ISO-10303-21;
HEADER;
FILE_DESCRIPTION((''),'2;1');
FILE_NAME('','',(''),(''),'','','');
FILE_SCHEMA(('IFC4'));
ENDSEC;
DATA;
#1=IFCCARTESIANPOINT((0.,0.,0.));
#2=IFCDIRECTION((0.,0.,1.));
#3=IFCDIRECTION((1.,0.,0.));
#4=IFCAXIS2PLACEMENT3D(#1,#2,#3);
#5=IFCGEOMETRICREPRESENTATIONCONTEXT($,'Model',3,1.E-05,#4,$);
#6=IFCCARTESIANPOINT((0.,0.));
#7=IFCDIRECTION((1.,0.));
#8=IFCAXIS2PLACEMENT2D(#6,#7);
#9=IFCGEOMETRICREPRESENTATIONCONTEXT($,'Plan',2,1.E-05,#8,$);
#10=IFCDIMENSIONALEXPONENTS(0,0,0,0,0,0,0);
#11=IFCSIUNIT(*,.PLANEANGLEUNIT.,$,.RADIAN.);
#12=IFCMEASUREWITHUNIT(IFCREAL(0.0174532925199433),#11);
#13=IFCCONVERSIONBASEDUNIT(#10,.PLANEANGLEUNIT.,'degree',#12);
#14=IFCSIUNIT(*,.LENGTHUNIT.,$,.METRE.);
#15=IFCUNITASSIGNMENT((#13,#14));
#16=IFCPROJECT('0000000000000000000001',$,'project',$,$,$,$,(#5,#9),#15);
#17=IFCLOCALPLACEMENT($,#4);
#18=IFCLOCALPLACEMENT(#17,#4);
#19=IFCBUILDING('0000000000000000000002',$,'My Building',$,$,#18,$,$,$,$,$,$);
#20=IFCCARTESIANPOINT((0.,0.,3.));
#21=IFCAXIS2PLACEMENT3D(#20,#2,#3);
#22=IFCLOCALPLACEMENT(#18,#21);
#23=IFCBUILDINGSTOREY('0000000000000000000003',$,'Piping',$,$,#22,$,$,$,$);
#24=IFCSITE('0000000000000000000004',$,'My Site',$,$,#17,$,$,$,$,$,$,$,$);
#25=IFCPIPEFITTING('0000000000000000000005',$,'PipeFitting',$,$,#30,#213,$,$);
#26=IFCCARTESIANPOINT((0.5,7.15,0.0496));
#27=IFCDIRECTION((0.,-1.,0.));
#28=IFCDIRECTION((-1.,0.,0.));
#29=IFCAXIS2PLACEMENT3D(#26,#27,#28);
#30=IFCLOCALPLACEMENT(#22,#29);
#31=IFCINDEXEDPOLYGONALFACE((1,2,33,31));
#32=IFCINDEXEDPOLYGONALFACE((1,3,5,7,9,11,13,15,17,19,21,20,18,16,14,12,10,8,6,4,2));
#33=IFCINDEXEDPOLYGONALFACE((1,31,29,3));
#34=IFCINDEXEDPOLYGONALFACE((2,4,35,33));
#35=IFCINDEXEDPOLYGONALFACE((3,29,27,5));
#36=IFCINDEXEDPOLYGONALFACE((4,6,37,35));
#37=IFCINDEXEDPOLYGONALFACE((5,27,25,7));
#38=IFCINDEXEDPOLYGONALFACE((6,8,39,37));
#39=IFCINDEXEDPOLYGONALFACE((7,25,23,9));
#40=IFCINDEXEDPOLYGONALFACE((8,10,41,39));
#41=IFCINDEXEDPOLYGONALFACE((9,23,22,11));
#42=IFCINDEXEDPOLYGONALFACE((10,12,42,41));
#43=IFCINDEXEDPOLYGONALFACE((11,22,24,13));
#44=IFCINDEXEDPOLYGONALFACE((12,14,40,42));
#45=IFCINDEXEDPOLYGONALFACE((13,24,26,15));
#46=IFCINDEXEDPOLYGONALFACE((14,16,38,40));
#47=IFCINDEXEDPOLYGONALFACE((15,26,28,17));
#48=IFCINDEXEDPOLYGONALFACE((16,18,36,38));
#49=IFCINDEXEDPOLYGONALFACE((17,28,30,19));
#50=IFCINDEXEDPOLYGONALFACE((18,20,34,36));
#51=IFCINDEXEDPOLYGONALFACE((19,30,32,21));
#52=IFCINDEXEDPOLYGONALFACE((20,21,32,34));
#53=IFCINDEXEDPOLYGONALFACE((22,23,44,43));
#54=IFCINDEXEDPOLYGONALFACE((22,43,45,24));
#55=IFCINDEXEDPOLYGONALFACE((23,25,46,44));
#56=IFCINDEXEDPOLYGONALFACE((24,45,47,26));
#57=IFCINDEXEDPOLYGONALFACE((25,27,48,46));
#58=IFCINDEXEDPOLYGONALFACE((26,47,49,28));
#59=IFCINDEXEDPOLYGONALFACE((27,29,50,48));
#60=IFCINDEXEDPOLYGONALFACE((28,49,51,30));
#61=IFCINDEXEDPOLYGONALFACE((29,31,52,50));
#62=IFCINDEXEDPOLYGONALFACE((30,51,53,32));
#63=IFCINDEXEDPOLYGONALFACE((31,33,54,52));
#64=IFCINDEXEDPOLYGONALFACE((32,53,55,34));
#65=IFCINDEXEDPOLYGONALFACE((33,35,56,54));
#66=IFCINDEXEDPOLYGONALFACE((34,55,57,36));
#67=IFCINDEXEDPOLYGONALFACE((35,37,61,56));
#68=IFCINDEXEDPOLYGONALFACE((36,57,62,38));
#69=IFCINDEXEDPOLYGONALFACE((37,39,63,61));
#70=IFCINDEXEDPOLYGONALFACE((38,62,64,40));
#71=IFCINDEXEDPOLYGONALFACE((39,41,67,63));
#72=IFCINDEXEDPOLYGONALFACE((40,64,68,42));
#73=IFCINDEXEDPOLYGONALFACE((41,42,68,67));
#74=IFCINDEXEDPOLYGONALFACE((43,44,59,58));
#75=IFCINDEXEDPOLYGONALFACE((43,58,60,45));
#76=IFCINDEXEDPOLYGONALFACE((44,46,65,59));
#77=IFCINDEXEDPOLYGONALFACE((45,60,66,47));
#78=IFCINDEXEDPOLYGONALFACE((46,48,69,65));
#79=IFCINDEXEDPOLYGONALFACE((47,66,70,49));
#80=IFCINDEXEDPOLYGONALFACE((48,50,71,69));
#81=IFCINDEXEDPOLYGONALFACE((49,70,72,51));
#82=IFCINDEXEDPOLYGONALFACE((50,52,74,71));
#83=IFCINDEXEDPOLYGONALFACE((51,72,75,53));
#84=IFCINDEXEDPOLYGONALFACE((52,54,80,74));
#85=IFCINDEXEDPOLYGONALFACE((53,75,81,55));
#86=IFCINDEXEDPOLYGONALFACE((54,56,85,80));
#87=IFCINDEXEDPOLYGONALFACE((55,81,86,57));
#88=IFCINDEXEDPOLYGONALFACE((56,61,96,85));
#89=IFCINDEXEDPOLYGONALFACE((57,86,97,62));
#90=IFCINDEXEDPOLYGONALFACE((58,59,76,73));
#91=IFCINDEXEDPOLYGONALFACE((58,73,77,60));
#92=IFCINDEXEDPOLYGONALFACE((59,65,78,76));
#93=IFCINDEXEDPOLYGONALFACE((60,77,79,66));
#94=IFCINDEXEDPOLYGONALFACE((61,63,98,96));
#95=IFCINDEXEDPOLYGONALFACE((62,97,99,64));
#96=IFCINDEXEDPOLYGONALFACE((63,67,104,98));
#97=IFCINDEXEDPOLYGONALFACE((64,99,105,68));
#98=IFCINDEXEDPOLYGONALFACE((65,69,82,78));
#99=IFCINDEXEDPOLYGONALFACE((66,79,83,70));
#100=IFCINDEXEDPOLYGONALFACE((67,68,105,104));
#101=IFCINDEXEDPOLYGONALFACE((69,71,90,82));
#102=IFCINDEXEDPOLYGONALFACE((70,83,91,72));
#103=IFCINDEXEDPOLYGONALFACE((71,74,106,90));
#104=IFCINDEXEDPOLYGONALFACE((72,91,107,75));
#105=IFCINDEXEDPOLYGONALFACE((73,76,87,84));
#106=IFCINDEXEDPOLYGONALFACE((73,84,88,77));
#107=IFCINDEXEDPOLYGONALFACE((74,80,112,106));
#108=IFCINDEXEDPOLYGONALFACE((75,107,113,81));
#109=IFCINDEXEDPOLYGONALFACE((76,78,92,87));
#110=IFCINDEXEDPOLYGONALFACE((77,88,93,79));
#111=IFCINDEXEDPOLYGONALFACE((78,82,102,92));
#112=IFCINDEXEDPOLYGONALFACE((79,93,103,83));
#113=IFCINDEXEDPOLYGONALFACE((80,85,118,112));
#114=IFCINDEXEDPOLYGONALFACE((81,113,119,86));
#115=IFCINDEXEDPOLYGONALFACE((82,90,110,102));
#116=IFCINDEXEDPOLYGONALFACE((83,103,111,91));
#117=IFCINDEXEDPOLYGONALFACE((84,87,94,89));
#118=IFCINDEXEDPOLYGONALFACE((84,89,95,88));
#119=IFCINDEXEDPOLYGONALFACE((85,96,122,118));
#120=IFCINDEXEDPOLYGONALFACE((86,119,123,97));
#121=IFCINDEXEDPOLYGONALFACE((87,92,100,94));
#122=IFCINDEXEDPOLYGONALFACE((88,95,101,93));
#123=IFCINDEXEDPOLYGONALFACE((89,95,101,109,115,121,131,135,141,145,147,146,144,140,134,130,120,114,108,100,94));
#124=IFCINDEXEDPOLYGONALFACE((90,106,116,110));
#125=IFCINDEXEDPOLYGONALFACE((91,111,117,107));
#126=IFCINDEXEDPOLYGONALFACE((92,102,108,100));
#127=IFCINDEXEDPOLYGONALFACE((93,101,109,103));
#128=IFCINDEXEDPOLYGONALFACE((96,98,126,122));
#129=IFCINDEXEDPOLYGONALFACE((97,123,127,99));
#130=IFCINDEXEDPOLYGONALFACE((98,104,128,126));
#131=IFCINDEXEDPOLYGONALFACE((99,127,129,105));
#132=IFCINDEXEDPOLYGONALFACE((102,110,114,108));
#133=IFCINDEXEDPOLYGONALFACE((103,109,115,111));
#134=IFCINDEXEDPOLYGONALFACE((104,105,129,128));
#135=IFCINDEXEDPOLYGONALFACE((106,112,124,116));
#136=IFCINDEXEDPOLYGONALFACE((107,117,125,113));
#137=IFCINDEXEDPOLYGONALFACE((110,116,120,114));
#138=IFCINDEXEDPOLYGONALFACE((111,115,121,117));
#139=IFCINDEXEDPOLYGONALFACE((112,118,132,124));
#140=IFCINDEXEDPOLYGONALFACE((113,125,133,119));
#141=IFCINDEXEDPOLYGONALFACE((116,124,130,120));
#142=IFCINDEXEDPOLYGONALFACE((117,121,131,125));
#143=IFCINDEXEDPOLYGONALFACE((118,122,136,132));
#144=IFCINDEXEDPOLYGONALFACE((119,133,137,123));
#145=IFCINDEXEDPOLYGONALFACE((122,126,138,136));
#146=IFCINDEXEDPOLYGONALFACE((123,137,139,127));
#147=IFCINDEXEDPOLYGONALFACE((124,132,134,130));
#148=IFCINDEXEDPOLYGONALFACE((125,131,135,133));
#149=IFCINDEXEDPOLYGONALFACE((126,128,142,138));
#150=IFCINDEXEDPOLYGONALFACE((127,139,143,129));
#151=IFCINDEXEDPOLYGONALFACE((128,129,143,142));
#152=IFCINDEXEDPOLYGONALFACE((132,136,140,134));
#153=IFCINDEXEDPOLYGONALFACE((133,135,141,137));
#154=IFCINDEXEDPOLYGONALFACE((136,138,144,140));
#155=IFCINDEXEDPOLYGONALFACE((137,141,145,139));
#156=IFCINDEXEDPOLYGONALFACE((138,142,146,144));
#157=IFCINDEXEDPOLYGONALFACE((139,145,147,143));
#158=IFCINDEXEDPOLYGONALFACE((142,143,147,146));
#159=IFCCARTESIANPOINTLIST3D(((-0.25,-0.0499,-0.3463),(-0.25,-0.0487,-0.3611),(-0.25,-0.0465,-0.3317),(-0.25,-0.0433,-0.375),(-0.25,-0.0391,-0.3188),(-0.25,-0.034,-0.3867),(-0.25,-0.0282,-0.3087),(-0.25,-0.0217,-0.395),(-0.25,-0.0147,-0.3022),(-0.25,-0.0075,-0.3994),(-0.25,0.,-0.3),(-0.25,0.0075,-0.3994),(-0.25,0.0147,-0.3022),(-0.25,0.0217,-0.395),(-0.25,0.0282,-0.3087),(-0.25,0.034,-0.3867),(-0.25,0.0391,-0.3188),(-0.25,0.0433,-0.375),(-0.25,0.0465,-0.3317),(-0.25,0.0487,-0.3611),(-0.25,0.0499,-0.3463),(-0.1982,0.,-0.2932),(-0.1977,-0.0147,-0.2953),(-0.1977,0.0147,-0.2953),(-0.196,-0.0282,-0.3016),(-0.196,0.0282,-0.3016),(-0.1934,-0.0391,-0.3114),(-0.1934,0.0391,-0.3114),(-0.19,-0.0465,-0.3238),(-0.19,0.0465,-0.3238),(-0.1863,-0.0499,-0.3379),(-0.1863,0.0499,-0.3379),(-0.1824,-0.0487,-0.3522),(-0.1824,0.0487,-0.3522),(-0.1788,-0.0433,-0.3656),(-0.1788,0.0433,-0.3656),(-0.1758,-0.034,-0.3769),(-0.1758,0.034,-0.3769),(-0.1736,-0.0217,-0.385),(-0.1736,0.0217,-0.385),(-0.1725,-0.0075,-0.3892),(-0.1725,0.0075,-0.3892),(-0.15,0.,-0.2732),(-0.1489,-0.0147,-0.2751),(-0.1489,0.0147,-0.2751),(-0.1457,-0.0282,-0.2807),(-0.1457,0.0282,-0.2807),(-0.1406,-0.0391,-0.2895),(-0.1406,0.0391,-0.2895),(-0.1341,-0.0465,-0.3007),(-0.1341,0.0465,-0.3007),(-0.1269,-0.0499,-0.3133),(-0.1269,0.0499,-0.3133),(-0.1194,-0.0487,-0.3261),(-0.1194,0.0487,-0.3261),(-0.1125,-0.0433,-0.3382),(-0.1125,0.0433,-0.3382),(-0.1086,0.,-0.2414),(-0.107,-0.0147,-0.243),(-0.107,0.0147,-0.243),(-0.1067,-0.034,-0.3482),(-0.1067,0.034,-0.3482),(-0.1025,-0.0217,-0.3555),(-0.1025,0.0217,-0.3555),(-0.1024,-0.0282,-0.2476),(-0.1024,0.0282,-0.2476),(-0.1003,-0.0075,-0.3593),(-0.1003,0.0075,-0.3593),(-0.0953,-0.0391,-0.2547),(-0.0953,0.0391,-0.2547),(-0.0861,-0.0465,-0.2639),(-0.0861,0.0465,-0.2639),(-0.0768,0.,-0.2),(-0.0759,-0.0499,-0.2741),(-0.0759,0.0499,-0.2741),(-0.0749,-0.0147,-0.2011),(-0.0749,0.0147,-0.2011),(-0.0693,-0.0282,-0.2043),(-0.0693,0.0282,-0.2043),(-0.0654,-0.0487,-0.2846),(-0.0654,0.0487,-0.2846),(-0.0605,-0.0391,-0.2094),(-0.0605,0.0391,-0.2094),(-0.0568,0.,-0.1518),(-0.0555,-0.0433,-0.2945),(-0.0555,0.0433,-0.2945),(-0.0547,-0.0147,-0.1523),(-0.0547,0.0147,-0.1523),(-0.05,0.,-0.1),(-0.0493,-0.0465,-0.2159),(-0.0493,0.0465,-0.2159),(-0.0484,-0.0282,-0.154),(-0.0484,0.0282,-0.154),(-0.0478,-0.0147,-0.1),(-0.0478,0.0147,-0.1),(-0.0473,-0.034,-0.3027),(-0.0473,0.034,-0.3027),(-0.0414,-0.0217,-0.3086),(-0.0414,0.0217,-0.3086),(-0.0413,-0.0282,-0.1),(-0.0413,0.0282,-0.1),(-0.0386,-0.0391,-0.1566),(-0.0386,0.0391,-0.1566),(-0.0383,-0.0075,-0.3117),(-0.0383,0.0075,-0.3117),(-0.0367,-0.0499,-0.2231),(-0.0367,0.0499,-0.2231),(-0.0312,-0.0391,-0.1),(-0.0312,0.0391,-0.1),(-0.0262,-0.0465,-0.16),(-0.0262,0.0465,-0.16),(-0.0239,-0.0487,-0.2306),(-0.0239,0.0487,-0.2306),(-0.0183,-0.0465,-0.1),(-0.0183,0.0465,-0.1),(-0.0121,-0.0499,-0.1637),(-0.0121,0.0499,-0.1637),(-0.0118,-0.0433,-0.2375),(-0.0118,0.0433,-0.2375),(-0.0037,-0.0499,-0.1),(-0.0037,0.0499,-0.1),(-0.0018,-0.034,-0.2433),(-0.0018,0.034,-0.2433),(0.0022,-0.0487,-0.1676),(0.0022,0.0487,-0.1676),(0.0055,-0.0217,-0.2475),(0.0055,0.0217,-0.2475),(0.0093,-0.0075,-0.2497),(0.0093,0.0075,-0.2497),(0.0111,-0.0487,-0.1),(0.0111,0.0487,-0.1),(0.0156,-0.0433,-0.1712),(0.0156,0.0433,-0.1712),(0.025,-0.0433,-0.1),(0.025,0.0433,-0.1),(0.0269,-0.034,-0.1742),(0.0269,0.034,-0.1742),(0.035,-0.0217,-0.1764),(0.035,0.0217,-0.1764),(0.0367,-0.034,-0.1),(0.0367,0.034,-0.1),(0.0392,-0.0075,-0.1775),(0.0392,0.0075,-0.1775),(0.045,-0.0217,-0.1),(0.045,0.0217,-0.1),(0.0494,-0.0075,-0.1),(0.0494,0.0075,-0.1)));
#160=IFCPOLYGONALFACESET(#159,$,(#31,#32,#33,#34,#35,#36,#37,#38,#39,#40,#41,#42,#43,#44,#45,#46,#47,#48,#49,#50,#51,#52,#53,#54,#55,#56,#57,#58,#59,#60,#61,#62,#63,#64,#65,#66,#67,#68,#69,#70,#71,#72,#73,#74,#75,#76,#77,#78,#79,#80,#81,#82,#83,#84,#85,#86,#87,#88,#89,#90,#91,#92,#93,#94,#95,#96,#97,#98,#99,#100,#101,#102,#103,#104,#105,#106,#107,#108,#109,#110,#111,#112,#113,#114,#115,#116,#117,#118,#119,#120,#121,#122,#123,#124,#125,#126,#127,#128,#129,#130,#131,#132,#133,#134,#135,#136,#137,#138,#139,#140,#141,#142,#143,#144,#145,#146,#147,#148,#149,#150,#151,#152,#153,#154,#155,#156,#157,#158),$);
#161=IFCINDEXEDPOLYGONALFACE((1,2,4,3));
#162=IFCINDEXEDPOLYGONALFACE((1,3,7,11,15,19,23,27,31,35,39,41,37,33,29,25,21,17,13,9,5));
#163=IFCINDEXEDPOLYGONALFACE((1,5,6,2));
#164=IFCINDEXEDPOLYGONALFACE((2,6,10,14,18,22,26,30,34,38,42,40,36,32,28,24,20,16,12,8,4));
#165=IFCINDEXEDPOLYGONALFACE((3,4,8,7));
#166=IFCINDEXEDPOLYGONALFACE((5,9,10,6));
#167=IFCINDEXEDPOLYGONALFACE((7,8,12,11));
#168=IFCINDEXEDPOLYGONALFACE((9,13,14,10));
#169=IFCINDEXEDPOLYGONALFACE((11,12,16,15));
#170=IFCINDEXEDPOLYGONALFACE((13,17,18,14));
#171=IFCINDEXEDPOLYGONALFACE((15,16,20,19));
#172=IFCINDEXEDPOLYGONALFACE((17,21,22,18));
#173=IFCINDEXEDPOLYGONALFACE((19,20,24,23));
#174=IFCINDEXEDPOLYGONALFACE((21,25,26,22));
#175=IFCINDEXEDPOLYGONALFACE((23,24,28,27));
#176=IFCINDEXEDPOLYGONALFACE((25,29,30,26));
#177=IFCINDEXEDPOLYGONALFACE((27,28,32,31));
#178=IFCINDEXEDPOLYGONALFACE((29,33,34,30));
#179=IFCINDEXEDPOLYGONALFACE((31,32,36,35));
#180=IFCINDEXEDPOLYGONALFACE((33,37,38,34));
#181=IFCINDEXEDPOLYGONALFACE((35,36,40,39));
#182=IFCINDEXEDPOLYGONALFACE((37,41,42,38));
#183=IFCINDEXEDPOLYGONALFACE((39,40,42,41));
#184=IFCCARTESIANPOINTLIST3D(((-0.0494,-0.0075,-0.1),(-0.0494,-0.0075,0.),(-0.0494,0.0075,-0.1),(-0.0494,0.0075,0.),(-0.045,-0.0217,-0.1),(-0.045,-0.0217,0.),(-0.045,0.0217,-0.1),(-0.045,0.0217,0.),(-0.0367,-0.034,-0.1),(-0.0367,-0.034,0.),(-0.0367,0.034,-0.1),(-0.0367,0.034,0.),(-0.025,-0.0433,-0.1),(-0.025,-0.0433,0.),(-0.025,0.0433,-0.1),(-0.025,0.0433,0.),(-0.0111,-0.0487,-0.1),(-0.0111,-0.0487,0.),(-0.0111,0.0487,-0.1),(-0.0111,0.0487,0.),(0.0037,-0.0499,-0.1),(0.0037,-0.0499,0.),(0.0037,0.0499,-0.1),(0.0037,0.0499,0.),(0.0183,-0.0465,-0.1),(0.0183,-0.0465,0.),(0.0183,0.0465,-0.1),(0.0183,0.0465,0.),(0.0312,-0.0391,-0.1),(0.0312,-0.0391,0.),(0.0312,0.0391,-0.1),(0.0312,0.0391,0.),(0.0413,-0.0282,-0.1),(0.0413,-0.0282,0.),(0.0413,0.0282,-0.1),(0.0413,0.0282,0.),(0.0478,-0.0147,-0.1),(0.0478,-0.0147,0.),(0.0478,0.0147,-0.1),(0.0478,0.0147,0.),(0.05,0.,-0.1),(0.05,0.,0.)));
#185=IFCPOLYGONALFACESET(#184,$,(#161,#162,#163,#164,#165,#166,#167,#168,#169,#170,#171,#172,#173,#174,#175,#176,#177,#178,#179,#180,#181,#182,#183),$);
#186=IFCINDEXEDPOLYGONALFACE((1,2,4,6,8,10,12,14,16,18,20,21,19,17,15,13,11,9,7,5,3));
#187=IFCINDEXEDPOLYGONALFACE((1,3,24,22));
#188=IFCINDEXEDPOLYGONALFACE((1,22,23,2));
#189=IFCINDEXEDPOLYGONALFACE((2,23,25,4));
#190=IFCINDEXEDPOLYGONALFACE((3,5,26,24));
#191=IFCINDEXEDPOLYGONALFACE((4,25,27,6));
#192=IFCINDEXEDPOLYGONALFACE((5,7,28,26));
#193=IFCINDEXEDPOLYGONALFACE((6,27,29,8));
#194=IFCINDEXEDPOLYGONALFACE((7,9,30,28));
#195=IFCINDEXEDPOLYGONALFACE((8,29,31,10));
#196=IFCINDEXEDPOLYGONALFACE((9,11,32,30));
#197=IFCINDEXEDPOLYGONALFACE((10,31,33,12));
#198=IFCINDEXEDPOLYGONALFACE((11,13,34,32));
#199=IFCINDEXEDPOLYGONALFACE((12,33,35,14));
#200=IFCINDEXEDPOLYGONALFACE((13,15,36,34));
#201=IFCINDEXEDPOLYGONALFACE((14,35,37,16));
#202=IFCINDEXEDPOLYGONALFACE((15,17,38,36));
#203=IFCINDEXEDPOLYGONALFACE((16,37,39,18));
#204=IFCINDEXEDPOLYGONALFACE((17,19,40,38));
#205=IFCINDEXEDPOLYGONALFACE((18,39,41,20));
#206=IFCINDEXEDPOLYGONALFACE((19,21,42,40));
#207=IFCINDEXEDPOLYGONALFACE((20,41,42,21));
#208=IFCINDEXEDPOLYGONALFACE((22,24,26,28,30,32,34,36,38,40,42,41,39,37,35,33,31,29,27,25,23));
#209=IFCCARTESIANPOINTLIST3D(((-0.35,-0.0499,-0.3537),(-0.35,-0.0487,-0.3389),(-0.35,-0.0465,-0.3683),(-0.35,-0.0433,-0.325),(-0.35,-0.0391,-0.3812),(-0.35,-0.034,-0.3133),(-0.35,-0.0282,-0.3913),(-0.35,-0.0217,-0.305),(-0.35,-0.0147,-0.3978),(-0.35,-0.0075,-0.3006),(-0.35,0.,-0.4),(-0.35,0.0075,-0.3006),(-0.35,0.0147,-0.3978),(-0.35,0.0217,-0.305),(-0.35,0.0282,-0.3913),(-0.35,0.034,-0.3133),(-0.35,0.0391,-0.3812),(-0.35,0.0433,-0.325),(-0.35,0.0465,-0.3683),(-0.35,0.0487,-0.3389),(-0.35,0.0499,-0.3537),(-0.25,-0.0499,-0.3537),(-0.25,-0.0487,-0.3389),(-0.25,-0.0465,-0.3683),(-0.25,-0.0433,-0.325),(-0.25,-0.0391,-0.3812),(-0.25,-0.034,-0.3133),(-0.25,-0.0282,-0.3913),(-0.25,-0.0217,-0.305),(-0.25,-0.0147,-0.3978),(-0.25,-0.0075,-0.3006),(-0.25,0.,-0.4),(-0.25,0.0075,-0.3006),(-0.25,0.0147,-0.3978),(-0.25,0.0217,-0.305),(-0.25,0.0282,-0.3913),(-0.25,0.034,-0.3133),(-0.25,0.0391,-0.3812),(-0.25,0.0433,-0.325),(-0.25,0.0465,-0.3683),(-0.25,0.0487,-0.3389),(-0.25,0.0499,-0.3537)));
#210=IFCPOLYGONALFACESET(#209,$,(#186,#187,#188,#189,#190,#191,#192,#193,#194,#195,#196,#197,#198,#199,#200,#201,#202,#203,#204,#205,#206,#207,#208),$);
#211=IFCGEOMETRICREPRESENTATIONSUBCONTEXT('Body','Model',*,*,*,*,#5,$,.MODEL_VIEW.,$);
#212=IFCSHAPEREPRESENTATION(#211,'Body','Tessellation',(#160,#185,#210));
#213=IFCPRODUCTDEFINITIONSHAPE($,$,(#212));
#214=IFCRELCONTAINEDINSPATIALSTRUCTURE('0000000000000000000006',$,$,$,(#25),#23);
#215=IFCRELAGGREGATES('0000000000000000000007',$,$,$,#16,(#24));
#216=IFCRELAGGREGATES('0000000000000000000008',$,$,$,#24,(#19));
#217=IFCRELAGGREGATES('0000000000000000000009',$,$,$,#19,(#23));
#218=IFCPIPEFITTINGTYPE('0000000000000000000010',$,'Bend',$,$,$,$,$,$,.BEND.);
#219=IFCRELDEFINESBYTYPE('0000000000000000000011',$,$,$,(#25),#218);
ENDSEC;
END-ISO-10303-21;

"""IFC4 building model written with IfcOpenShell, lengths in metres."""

from ifc_helpers import new_model, entity, si_unit, converted_unit, frame, origin_with_axes, origin_2d_with_axis, place, context, subcontext, project, spatial, circle, extrude, source, transform, mapped, type_object, type_shapes, element, save


model = new_model("IFC4")

# Units and contexts
model_context = context("Model", 3, precision=1e-05, world=origin_with_axes())
plan_context = context("Plan", 2, precision=1e-05, world=origin_2d_with_axis())
body_context = subcontext(model_context, "Body", "Model", "MODEL_VIEW")
ifc_project = project(units=[converted_unit("PLANEANGLEUNIT", "degree", entity("IfcReal", 0.0174532925199433), si_unit("PLANEANGLEUNIT", "RADIAN"), dimensions=[0, 0, 0, 0, 0, 0, 0]), si_unit("LENGTHUNIT", "METRE")], contexts=[model_context, plan_context])

# Site, building, storey
site_placement = place(None, origin_with_axes())
site = spatial("IfcSite", under=ifc_project, at=site_placement, Name="My Site")
building_placement = place(site_placement, origin_with_axes())
building = spatial("IfcBuilding", under=site, at=building_placement, Name="My Building")
storey_placement = place(building_placement, frame((0.0, 0.0, 3.0), z_axis=(0.0, 0.0, 1.0), x_axis=(1.0, 0.0, 0.0)))
storey = spatial("IfcBuildingStorey", under=building, at=storey_placement, Name="Piping")

# Pipe fitting
pipe_fitting_type_1 = type_object("IfcPipeFittingType", Name="Bend", PredefinedType="BEND")
shared_shape = source(origin_with_axes(), body_context, "Body", "SolidModel", [
    entity("IfcSweptDiskSolid", entity("IfcIndexedPolyCurve", entity("IfcCartesianPointList3D", [[0.0, 0.0, -0.1], [-0.0732, 0.0, -0.2768], [-0.25, 0.0, -0.35]]), [entity("IfcArcIndex", [1, 2, 3])]), 0.05),
    extrude(circle(Radius=0.05), origin_with_axes(), (0.0, 0.0, -1.0), 0.1),
    extrude(circle(Radius=0.05), frame((-0.25, 0.0, -0.35), z_axis=(-1.0, 0.0, 0.0), x_axis=(0.0, 0.0, -1.0)), (0.0, 0.0, 1.0), 0.1),
])
type_shapes(pipe_fitting_type_1, [shared_shape])
for number, where, z_axis, x_axis, name in (
    (1, (0.5, 7.15, 0.0496), (0.0, -1.0, 0.0), (-1.0, 0.0, 0.0), "PipeFitting"),
):
    element("IfcPipeFitting", number, at=place(storey_placement, frame(where, z_axis=z_axis, x_axis=x_axis)), inside=storey, type_object=pipe_fitting_type_1, Name=name, context=body_context, shape_type="MappedRepresentation", body=[
        mapped(shared_shape, transform((0.0, 0.0, 0.0), x_axis=(1.0, 0.0, 0.0), y_axis=(0.0, 1.0, 0.0), z_axis=(0.0, 0.0, 1.0), scale=1.0)),
    ])

save(model, "model.ifc")
